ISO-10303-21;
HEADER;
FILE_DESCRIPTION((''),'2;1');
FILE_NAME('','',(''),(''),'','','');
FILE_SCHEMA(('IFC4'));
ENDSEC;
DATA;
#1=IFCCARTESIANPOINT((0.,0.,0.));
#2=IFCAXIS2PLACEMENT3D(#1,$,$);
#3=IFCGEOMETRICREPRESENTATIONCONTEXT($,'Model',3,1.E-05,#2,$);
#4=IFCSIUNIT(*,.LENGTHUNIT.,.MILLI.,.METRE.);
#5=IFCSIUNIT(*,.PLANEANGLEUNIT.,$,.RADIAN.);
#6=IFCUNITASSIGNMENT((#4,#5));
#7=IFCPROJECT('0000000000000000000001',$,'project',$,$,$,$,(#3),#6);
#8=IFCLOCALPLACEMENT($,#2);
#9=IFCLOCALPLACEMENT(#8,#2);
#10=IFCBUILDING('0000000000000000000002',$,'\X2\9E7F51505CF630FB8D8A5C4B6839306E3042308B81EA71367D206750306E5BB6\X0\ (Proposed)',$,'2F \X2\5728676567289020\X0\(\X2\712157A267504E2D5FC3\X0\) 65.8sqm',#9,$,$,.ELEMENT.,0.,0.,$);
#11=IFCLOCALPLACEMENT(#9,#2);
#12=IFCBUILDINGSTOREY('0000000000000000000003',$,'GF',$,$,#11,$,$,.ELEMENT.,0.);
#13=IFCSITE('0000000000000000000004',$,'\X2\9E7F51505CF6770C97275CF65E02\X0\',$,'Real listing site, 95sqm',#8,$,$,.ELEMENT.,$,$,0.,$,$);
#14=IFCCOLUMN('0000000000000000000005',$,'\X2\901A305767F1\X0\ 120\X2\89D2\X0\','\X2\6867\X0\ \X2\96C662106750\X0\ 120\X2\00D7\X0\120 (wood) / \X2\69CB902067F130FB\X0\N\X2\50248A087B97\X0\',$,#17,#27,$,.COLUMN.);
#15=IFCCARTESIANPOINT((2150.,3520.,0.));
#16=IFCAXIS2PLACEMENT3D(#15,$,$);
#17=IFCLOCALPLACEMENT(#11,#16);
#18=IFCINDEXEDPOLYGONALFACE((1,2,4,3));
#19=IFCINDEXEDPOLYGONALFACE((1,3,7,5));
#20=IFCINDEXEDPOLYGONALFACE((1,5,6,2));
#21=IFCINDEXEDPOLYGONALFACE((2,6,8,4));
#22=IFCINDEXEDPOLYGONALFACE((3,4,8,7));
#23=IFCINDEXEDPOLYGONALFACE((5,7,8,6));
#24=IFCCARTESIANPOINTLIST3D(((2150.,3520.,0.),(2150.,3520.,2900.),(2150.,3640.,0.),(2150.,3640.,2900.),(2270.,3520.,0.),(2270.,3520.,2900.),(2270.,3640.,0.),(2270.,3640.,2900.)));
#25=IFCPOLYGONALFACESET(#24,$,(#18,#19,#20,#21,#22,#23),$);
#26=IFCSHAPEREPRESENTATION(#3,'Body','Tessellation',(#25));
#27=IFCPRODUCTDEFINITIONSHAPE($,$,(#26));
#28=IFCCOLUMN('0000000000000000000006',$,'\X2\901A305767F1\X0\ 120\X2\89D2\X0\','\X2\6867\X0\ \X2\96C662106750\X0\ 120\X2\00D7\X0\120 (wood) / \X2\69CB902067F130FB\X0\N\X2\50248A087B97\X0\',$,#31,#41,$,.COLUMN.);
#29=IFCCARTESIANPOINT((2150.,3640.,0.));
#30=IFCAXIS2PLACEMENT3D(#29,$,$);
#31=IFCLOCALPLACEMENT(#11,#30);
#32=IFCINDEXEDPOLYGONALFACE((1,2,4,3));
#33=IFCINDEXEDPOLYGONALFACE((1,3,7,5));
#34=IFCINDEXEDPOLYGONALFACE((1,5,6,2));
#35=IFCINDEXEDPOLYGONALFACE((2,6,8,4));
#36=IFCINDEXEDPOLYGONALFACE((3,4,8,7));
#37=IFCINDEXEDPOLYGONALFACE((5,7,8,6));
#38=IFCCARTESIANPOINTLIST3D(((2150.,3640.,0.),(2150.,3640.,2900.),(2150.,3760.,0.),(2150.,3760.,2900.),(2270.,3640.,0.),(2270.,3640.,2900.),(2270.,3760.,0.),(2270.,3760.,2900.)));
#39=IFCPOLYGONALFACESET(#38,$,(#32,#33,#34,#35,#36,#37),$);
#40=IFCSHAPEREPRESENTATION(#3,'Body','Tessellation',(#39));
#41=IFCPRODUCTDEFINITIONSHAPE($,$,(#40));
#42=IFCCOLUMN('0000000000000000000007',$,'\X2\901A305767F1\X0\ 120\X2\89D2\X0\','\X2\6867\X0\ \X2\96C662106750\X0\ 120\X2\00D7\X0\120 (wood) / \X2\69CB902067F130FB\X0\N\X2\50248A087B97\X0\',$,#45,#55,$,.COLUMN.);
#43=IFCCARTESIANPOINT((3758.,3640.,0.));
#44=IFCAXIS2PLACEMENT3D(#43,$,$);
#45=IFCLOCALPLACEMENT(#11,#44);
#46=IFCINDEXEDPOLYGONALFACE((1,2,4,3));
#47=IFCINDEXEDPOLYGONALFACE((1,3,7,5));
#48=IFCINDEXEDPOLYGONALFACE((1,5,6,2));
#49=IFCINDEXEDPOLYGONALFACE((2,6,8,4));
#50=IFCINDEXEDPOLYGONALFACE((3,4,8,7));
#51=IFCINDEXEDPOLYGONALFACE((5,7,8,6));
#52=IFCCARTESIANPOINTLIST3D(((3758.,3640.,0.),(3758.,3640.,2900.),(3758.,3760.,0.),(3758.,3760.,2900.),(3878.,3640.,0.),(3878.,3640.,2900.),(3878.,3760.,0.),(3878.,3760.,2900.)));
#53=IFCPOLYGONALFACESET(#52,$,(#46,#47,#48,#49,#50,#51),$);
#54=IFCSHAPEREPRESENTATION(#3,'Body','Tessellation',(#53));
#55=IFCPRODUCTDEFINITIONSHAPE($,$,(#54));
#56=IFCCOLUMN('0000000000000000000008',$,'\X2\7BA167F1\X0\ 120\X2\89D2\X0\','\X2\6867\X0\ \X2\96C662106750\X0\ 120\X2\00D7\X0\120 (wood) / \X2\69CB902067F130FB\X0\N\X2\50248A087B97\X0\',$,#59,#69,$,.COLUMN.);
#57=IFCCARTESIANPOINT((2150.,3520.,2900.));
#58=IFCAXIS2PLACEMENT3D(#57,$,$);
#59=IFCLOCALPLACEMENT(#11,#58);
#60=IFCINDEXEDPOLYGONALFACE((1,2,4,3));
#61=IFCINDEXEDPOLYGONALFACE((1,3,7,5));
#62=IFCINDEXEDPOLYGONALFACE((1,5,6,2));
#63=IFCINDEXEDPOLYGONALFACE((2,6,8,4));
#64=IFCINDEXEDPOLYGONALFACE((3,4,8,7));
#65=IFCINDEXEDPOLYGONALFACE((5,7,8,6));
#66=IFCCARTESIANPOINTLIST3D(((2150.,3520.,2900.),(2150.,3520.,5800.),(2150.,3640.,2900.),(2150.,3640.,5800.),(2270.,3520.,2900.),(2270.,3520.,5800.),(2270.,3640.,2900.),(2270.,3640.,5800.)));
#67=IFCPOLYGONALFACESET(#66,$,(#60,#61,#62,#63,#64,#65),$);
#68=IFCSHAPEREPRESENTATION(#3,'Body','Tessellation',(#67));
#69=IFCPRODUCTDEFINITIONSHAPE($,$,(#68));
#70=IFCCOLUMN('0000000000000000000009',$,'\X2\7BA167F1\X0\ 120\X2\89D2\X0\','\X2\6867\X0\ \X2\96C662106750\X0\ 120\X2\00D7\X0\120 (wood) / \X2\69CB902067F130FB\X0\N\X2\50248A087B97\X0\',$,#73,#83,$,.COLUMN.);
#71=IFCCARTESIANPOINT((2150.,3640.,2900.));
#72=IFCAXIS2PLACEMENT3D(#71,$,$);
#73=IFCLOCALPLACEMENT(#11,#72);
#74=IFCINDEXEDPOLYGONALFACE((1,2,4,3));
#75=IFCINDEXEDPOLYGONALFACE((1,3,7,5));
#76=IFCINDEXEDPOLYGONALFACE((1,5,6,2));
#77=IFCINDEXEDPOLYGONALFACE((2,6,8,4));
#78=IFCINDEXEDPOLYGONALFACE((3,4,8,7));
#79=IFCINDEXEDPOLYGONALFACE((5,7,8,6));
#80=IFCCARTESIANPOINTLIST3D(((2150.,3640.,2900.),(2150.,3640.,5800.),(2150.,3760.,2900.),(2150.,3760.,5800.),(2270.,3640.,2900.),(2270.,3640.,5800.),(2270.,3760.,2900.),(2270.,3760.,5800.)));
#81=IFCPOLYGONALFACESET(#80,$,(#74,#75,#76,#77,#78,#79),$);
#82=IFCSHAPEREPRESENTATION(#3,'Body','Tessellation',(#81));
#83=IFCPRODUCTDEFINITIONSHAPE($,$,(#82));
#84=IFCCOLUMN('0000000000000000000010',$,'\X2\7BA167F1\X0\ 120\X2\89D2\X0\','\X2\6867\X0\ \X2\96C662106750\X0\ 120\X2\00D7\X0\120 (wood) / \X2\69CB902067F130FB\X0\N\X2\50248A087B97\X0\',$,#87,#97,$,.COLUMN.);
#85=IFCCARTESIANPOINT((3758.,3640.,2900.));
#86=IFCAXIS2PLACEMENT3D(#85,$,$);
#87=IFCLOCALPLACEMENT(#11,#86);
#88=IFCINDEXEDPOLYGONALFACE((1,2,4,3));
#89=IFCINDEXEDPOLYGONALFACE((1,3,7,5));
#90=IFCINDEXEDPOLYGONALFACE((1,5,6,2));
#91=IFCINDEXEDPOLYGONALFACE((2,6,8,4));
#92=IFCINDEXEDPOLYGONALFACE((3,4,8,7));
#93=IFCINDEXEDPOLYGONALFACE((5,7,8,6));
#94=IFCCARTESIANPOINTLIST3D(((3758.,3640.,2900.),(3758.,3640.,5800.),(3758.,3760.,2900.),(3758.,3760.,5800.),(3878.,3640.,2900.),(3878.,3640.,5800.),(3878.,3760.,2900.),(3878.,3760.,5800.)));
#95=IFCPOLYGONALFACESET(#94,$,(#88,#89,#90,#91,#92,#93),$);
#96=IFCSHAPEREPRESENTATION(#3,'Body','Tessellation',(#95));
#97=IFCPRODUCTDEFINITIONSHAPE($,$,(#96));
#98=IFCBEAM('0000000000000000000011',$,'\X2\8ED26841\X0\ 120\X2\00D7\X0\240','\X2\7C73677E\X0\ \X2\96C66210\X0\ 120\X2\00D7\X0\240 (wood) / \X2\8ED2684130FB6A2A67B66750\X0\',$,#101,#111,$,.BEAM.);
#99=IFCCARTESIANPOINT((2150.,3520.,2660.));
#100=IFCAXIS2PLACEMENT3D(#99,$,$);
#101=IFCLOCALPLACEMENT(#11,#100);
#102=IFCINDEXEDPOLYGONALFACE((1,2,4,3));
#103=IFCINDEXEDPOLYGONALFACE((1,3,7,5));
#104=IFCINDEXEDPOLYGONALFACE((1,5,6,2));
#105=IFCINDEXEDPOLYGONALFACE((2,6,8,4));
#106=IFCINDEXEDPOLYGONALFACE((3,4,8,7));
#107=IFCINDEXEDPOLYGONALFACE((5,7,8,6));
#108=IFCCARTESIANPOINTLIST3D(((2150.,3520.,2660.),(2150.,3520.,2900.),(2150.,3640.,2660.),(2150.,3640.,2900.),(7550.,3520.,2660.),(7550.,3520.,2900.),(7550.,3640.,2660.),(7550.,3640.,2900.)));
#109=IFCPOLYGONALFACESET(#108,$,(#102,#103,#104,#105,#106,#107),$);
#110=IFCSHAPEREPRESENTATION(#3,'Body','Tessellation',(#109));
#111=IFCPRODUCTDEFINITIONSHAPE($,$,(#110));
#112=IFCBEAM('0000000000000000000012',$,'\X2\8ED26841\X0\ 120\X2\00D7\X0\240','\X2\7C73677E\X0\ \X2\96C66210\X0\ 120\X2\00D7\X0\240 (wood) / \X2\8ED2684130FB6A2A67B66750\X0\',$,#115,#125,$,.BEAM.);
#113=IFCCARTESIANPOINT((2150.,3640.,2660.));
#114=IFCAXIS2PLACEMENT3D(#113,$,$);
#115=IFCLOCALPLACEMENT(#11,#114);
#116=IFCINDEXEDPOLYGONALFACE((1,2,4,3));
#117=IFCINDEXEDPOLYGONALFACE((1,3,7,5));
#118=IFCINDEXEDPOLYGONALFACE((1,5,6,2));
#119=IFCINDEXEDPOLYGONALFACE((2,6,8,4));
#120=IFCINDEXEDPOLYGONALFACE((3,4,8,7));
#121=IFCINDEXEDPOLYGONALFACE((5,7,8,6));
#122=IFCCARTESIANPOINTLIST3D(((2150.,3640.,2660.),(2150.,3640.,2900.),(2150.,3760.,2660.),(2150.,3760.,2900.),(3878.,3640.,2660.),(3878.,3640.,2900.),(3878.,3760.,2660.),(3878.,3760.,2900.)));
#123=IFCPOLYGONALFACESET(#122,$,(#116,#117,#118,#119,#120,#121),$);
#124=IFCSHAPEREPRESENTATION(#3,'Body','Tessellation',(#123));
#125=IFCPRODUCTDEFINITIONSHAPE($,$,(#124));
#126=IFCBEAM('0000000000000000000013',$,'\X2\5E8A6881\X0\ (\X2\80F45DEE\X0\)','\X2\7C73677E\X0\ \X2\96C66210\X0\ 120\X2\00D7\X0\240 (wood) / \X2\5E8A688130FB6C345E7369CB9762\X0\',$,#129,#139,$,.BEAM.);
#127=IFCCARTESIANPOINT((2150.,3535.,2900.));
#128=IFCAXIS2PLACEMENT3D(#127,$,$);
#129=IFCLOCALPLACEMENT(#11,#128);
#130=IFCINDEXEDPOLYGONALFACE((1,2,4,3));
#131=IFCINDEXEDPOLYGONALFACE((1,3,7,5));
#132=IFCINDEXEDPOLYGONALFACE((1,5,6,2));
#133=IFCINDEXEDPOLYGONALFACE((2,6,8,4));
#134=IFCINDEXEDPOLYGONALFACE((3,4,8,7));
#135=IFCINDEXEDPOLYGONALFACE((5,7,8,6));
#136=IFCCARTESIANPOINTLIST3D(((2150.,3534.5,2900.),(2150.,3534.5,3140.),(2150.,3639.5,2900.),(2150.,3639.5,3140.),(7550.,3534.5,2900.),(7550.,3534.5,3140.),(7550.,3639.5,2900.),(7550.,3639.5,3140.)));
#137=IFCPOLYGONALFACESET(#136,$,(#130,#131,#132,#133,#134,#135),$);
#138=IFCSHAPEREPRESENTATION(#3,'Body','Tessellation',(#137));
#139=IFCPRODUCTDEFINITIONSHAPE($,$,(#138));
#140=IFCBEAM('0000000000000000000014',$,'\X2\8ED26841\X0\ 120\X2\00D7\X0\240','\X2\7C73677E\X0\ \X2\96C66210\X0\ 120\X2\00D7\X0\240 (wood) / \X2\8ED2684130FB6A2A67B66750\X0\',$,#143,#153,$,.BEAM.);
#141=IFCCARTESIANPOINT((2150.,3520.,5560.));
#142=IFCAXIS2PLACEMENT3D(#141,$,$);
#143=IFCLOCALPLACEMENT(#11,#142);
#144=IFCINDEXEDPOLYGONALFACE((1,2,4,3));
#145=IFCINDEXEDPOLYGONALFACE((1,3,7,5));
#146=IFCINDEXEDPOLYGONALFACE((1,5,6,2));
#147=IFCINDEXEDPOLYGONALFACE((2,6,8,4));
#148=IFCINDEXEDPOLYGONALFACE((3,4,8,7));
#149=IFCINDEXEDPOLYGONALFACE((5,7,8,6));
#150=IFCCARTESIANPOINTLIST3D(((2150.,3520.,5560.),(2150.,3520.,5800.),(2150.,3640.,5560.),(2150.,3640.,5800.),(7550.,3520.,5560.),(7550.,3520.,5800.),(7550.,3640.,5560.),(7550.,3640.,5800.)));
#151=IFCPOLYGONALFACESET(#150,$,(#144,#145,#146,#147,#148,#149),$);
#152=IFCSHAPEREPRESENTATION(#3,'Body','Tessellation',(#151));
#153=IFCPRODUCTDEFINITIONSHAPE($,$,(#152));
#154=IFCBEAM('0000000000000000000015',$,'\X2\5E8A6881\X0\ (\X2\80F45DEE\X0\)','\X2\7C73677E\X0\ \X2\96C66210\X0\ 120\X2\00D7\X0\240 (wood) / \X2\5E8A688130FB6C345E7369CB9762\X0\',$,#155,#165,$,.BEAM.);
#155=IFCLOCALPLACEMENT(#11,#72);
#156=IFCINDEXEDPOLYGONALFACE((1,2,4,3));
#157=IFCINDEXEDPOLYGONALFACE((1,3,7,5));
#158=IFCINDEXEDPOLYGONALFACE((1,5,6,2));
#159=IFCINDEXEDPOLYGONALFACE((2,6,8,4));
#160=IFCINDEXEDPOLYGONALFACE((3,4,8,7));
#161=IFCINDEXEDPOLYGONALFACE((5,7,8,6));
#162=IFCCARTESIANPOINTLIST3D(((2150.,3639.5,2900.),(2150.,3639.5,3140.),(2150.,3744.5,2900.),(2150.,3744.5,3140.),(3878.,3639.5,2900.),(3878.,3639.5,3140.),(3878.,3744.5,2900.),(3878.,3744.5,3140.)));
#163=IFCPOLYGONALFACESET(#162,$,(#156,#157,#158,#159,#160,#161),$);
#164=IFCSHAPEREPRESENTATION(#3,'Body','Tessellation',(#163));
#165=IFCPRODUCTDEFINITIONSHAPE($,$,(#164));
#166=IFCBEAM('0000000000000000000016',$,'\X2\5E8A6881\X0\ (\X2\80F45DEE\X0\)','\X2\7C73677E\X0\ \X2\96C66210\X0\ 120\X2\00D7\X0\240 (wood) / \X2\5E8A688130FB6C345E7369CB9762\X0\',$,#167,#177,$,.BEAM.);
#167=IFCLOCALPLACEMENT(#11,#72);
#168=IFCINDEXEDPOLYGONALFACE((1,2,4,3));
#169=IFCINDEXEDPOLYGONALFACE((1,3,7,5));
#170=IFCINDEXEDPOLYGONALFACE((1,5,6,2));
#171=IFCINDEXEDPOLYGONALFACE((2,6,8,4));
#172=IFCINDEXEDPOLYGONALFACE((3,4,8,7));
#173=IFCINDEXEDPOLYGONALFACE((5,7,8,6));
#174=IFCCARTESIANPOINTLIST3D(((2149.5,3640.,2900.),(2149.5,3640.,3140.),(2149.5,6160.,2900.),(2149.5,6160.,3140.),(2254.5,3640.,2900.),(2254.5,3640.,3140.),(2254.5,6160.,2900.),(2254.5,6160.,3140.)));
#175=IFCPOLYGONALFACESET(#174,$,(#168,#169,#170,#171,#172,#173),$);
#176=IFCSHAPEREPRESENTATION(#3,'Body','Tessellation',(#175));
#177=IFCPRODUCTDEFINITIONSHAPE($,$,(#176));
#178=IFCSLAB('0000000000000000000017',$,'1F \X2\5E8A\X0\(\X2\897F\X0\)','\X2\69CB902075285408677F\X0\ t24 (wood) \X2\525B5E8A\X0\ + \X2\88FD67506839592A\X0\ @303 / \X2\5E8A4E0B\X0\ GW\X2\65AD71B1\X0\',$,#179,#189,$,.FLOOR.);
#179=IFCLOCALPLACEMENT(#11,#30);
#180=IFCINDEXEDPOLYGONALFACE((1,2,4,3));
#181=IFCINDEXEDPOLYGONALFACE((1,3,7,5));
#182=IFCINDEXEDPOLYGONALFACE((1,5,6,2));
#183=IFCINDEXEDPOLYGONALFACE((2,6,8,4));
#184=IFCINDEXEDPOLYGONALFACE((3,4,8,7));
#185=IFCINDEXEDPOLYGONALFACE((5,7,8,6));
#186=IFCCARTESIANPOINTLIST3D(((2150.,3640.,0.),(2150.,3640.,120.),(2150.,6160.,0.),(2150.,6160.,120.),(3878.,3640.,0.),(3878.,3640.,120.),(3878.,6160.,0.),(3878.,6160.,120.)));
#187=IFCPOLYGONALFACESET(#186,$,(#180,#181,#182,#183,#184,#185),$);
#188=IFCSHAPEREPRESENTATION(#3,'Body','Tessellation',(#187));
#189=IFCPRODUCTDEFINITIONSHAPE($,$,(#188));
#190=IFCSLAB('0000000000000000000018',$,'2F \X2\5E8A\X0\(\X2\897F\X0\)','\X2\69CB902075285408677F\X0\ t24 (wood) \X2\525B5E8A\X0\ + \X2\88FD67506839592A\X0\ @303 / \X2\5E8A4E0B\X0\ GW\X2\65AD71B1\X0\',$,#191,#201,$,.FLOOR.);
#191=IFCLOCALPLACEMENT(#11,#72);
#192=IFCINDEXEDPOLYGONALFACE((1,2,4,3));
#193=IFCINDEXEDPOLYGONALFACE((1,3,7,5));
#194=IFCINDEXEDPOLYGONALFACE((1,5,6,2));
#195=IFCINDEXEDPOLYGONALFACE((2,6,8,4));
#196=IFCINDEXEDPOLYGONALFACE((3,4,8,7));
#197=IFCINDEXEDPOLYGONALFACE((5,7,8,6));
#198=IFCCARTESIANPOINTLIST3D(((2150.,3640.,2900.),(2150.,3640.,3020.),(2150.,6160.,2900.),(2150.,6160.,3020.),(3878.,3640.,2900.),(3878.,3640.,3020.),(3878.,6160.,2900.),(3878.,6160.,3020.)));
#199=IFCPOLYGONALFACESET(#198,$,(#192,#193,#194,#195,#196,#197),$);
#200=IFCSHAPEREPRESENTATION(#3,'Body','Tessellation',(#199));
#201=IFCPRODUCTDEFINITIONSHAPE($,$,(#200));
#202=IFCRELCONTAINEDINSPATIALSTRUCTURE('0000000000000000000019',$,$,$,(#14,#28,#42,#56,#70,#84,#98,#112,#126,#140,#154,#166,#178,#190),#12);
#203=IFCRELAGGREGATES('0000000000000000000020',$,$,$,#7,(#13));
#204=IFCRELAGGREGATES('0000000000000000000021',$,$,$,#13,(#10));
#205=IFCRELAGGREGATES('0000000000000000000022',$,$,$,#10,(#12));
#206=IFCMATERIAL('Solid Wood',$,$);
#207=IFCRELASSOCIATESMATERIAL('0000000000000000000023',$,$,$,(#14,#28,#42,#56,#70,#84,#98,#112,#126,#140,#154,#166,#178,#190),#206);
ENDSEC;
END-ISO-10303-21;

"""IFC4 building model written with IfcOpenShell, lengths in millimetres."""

from ifc_helpers import new_model, si_unit, frame, frame_2d, origin, place, context, project, spatial, rectangle, extrude, material, element, save


model = new_model("IFC4")

# Units and contexts
model_context = context("Model", 3, precision=1e-05, world=origin())
ifc_project = project(units=[si_unit("LENGTHUNIT", "METRE", prefix="MILLI"), si_unit("PLANEANGLEUNIT", "RADIAN")], contexts=[model_context])

# Site, building, storey
site_placement = place(None, origin())
site = spatial("IfcSite", under=ifc_project, at=site_placement, Name="鹿児島県霧島市", ObjectType="Real listing site, 95sqm", CompositionType="ELEMENT", RefElevation=0.0)
building_placement = place(site_placement, origin())
building = spatial("IfcBuilding", under=site, at=building_placement, Name="鹿児島・越屋根のある自然素材の家 (Proposed)", ObjectType="2F 在来木造(無垢材中心) 65.8sqm", CompositionType="ELEMENT", ElevationOfRefHeight=0.0, ElevationOfTerrain=0.0)
storey_placement = place(building_placement, origin())
storey = spatial("IfcBuildingStorey", under=building, at=storey_placement, Name="GF", CompositionType="ELEMENT", Elevation=0.0)

# Columns
ifc_material_1 = material(Name="Solid Wood")
column_1_placement = place(storey_placement, frame((2150.0, 3520.0, 0.0)))
element("IfcColumn", 1, at=column_1_placement, inside=storey, material=ifc_material_1, Name="通し柱 120角", Description="桧 集成材 120×120 (wood) / 構造柱・N値計算", PredefinedType="COLUMN", context=model_context, shape_type="SweptSolid", body=[
    extrude(rectangle(XDim=120.0, YDim=120.0, at=frame_2d((60.0, 60.0))), frame((2150.0, 3520.0, 0.0)), (0.0, 0.0, 1.0), 2900.0),
])
column_2_placement = place(storey_placement, frame((2150.0, 3640.0, 0.0)))
element("IfcColumn", 2, at=column_2_placement, inside=storey, material=ifc_material_1, Name="通し柱 120角", Description="桧 集成材 120×120 (wood) / 構造柱・N値計算", PredefinedType="COLUMN", context=model_context, shape_type="SweptSolid", body=[
    extrude(rectangle(XDim=120.0, YDim=120.0, at=frame_2d((60.0, 60.0))), frame((2150.0, 3640.0, 0.0)), (0.0, 0.0, 1.0), 2900.0),
])
column_3_placement = place(storey_placement, frame((3758.0, 3640.0, 0.0)))
element("IfcColumn", 3, at=column_3_placement, inside=storey, material=ifc_material_1, Name="通し柱 120角", Description="桧 集成材 120×120 (wood) / 構造柱・N値計算", PredefinedType="COLUMN", context=model_context, shape_type="SweptSolid", body=[
    extrude(rectangle(XDim=120.0, YDim=120.0, at=frame_2d((60.0, 60.0))), frame((3758.0, 3640.0, 0.0)), (0.0, 0.0, 1.0), 2900.0),
])
column_4_placement = place(storey_placement, frame((2150.0, 3520.0, 2900.0)))
element("IfcColumn", 4, at=column_4_placement, inside=storey, material=ifc_material_1, Name="管柱 120角", Description="桧 集成材 120×120 (wood) / 構造柱・N値計算", PredefinedType="COLUMN", context=model_context, shape_type="SweptSolid", body=[
    extrude(rectangle(XDim=120.0, YDim=120.0, at=frame_2d((60.0, 60.0))), frame((2150.0, 3520.0, 2900.0)), (0.0, 0.0, 1.0), 2900.0),
])
column_5_placement = place(storey_placement, frame((2150.0, 3640.0, 2900.0)))
element("IfcColumn", 5, at=column_5_placement, inside=storey, material=ifc_material_1, Name="管柱 120角", Description="桧 集成材 120×120 (wood) / 構造柱・N値計算", PredefinedType="COLUMN", context=model_context, shape_type="SweptSolid", body=[
    extrude(rectangle(XDim=120.0, YDim=120.0, at=frame_2d((60.0, 60.0))), frame((2150.0, 3640.0, 2900.0)), (0.0, 0.0, 1.0), 2900.0),
])
column_6_placement = place(storey_placement, frame((3758.0, 3640.0, 2900.0)))
element("IfcColumn", 6, at=column_6_placement, inside=storey, material=ifc_material_1, Name="管柱 120角", Description="桧 集成材 120×120 (wood) / 構造柱・N値計算", PredefinedType="COLUMN", context=model_context, shape_type="SweptSolid", body=[
    extrude(rectangle(XDim=120.0, YDim=120.0, at=frame_2d((60.0, 60.0))), frame((3758.0, 3640.0, 2900.0)), (0.0, 0.0, 1.0), 2900.0),
])

# Beams
beam_1_placement = place(storey_placement, frame((2150.0, 3520.0, 2660.0)))
element("IfcBeam", 7, at=beam_1_placement, inside=storey, material=ifc_material_1, Name="軒桁 120×240", Description="米松 集成 120×240 (wood) / 軒桁・横架材", PredefinedType="BEAM", context=model_context, shape_type="SweptSolid", body=[
    extrude(rectangle(XDim=5400.0, YDim=120.0, at=frame_2d((2700.0, 60.0))), frame((2150.0, 3520.0, 2660.0)), (0.0, 0.0, 1.0), 240.0),
])
beam_2_placement = place(storey_placement, frame((2150.0, 3640.0, 2660.0)))
element("IfcBeam", 8, at=beam_2_placement, inside=storey, material=ifc_material_1, Name="軒桁 120×240", Description="米松 集成 120×240 (wood) / 軒桁・横架材", PredefinedType="BEAM", context=model_context, shape_type="SweptSolid", body=[
    extrude(rectangle(XDim=1728.0, YDim=120.0, at=frame_2d((864.0, 60.0))), frame((2150.0, 3640.0, 2660.0)), (0.0, 0.0, 1.0), 240.0),
])
beam_3_placement = place(storey_placement, frame((2150.0, 3535.0, 2900.0)))
element("IfcBeam", 9, at=beam_3_placement, inside=storey, material=ifc_material_1, Name="床梁 (胴差)", Description="米松 集成 120×240 (wood) / 床梁・水平構面", PredefinedType="BEAM", context=model_context, shape_type="SweptSolid", body=[
    extrude(rectangle(XDim=5400.0, YDim=105.0, at=frame_2d((2700.0, 52.0))), frame((2150.0, 3535.0, 2900.0)), (0.0, 0.0, 1.0), 240.0),
])
beam_4_placement = place(storey_placement, frame((2150.0, 3520.0, 5560.0)))
element("IfcBeam", 10, at=beam_4_placement, inside=storey, material=ifc_material_1, Name="軒桁 120×240", Description="米松 集成 120×240 (wood) / 軒桁・横架材", PredefinedType="BEAM", context=model_context, shape_type="SweptSolid", body=[
    extrude(rectangle(XDim=5400.0, YDim=120.0, at=frame_2d((2700.0, 60.0))), frame((2150.0, 3520.0, 5560.0)), (0.0, 0.0, 1.0), 240.0),
])
beam_5_placement = place(storey_placement, frame((2150.0, 3640.0, 2900.0)))
element("IfcBeam", 11, at=beam_5_placement, inside=storey, material=ifc_material_1, Name="床梁 (胴差)", Description="米松 集成 120×240 (wood) / 床梁・水平構面", PredefinedType="BEAM", context=model_context, shape_type="SweptSolid", body=[
    extrude(rectangle(XDim=1728.0, YDim=105.0, at=frame_2d((864.0, 52.0))), frame((2150.0, 3640.0, 2900.0)), (0.0, 0.0, 1.0), 240.0),
])
beam_6_placement = place(storey_placement, frame((2150.0, 3640.0, 2900.0)))
element("IfcBeam", 12, at=beam_6_placement, inside=storey, material=ifc_material_1, Name="床梁 (胴差)", Description="米松 集成 120×240 (wood) / 床梁・水平構面", PredefinedType="BEAM", context=model_context, shape_type="SweptSolid", body=[
    extrude(rectangle(XDim=105.0, YDim=2520.0, at=frame_2d((52.0, 1260.0))), frame((2150.0, 3640.0, 2900.0)), (0.0, 0.0, 1.0), 240.0),
])

# Slabs
slab_1_placement = place(storey_placement, frame((2150.0, 3640.0, 0.0)))
element("IfcSlab", 13, at=slab_1_placement, inside=storey, material=ifc_material_1, Name="1F 床(西)", Description="構造用合板 t24 (wood) 剛床 + 製材根太 @303 / 床下 GW断熱", PredefinedType="FLOOR", context=model_context, shape_type="SweptSolid", body=[
    extrude(rectangle(XDim=1728.0, YDim=2520.0, at=frame_2d((864.0, 1260.0))), frame((2150.0, 3640.0, 0.0)), (0.0, 0.0, 1.0), 120.0),
])
slab_2_placement = place(storey_placement, frame((2150.0, 3640.0, 2900.0)))
element("IfcSlab", 14, at=slab_2_placement, inside=storey, material=ifc_material_1, Name="2F 床(西)", Description="構造用合板 t24 (wood) 剛床 + 製材根太 @303 / 床下 GW断熱", PredefinedType="FLOOR", context=model_context, shape_type="SweptSolid", body=[
    extrude(rectangle(XDim=1728.0, YDim=2520.0, at=frame_2d((864.0, 1260.0))), frame((2150.0, 3640.0, 2900.0)), (0.0, 0.0, 1.0), 120.0),
])

save(model, "model.ifc")
